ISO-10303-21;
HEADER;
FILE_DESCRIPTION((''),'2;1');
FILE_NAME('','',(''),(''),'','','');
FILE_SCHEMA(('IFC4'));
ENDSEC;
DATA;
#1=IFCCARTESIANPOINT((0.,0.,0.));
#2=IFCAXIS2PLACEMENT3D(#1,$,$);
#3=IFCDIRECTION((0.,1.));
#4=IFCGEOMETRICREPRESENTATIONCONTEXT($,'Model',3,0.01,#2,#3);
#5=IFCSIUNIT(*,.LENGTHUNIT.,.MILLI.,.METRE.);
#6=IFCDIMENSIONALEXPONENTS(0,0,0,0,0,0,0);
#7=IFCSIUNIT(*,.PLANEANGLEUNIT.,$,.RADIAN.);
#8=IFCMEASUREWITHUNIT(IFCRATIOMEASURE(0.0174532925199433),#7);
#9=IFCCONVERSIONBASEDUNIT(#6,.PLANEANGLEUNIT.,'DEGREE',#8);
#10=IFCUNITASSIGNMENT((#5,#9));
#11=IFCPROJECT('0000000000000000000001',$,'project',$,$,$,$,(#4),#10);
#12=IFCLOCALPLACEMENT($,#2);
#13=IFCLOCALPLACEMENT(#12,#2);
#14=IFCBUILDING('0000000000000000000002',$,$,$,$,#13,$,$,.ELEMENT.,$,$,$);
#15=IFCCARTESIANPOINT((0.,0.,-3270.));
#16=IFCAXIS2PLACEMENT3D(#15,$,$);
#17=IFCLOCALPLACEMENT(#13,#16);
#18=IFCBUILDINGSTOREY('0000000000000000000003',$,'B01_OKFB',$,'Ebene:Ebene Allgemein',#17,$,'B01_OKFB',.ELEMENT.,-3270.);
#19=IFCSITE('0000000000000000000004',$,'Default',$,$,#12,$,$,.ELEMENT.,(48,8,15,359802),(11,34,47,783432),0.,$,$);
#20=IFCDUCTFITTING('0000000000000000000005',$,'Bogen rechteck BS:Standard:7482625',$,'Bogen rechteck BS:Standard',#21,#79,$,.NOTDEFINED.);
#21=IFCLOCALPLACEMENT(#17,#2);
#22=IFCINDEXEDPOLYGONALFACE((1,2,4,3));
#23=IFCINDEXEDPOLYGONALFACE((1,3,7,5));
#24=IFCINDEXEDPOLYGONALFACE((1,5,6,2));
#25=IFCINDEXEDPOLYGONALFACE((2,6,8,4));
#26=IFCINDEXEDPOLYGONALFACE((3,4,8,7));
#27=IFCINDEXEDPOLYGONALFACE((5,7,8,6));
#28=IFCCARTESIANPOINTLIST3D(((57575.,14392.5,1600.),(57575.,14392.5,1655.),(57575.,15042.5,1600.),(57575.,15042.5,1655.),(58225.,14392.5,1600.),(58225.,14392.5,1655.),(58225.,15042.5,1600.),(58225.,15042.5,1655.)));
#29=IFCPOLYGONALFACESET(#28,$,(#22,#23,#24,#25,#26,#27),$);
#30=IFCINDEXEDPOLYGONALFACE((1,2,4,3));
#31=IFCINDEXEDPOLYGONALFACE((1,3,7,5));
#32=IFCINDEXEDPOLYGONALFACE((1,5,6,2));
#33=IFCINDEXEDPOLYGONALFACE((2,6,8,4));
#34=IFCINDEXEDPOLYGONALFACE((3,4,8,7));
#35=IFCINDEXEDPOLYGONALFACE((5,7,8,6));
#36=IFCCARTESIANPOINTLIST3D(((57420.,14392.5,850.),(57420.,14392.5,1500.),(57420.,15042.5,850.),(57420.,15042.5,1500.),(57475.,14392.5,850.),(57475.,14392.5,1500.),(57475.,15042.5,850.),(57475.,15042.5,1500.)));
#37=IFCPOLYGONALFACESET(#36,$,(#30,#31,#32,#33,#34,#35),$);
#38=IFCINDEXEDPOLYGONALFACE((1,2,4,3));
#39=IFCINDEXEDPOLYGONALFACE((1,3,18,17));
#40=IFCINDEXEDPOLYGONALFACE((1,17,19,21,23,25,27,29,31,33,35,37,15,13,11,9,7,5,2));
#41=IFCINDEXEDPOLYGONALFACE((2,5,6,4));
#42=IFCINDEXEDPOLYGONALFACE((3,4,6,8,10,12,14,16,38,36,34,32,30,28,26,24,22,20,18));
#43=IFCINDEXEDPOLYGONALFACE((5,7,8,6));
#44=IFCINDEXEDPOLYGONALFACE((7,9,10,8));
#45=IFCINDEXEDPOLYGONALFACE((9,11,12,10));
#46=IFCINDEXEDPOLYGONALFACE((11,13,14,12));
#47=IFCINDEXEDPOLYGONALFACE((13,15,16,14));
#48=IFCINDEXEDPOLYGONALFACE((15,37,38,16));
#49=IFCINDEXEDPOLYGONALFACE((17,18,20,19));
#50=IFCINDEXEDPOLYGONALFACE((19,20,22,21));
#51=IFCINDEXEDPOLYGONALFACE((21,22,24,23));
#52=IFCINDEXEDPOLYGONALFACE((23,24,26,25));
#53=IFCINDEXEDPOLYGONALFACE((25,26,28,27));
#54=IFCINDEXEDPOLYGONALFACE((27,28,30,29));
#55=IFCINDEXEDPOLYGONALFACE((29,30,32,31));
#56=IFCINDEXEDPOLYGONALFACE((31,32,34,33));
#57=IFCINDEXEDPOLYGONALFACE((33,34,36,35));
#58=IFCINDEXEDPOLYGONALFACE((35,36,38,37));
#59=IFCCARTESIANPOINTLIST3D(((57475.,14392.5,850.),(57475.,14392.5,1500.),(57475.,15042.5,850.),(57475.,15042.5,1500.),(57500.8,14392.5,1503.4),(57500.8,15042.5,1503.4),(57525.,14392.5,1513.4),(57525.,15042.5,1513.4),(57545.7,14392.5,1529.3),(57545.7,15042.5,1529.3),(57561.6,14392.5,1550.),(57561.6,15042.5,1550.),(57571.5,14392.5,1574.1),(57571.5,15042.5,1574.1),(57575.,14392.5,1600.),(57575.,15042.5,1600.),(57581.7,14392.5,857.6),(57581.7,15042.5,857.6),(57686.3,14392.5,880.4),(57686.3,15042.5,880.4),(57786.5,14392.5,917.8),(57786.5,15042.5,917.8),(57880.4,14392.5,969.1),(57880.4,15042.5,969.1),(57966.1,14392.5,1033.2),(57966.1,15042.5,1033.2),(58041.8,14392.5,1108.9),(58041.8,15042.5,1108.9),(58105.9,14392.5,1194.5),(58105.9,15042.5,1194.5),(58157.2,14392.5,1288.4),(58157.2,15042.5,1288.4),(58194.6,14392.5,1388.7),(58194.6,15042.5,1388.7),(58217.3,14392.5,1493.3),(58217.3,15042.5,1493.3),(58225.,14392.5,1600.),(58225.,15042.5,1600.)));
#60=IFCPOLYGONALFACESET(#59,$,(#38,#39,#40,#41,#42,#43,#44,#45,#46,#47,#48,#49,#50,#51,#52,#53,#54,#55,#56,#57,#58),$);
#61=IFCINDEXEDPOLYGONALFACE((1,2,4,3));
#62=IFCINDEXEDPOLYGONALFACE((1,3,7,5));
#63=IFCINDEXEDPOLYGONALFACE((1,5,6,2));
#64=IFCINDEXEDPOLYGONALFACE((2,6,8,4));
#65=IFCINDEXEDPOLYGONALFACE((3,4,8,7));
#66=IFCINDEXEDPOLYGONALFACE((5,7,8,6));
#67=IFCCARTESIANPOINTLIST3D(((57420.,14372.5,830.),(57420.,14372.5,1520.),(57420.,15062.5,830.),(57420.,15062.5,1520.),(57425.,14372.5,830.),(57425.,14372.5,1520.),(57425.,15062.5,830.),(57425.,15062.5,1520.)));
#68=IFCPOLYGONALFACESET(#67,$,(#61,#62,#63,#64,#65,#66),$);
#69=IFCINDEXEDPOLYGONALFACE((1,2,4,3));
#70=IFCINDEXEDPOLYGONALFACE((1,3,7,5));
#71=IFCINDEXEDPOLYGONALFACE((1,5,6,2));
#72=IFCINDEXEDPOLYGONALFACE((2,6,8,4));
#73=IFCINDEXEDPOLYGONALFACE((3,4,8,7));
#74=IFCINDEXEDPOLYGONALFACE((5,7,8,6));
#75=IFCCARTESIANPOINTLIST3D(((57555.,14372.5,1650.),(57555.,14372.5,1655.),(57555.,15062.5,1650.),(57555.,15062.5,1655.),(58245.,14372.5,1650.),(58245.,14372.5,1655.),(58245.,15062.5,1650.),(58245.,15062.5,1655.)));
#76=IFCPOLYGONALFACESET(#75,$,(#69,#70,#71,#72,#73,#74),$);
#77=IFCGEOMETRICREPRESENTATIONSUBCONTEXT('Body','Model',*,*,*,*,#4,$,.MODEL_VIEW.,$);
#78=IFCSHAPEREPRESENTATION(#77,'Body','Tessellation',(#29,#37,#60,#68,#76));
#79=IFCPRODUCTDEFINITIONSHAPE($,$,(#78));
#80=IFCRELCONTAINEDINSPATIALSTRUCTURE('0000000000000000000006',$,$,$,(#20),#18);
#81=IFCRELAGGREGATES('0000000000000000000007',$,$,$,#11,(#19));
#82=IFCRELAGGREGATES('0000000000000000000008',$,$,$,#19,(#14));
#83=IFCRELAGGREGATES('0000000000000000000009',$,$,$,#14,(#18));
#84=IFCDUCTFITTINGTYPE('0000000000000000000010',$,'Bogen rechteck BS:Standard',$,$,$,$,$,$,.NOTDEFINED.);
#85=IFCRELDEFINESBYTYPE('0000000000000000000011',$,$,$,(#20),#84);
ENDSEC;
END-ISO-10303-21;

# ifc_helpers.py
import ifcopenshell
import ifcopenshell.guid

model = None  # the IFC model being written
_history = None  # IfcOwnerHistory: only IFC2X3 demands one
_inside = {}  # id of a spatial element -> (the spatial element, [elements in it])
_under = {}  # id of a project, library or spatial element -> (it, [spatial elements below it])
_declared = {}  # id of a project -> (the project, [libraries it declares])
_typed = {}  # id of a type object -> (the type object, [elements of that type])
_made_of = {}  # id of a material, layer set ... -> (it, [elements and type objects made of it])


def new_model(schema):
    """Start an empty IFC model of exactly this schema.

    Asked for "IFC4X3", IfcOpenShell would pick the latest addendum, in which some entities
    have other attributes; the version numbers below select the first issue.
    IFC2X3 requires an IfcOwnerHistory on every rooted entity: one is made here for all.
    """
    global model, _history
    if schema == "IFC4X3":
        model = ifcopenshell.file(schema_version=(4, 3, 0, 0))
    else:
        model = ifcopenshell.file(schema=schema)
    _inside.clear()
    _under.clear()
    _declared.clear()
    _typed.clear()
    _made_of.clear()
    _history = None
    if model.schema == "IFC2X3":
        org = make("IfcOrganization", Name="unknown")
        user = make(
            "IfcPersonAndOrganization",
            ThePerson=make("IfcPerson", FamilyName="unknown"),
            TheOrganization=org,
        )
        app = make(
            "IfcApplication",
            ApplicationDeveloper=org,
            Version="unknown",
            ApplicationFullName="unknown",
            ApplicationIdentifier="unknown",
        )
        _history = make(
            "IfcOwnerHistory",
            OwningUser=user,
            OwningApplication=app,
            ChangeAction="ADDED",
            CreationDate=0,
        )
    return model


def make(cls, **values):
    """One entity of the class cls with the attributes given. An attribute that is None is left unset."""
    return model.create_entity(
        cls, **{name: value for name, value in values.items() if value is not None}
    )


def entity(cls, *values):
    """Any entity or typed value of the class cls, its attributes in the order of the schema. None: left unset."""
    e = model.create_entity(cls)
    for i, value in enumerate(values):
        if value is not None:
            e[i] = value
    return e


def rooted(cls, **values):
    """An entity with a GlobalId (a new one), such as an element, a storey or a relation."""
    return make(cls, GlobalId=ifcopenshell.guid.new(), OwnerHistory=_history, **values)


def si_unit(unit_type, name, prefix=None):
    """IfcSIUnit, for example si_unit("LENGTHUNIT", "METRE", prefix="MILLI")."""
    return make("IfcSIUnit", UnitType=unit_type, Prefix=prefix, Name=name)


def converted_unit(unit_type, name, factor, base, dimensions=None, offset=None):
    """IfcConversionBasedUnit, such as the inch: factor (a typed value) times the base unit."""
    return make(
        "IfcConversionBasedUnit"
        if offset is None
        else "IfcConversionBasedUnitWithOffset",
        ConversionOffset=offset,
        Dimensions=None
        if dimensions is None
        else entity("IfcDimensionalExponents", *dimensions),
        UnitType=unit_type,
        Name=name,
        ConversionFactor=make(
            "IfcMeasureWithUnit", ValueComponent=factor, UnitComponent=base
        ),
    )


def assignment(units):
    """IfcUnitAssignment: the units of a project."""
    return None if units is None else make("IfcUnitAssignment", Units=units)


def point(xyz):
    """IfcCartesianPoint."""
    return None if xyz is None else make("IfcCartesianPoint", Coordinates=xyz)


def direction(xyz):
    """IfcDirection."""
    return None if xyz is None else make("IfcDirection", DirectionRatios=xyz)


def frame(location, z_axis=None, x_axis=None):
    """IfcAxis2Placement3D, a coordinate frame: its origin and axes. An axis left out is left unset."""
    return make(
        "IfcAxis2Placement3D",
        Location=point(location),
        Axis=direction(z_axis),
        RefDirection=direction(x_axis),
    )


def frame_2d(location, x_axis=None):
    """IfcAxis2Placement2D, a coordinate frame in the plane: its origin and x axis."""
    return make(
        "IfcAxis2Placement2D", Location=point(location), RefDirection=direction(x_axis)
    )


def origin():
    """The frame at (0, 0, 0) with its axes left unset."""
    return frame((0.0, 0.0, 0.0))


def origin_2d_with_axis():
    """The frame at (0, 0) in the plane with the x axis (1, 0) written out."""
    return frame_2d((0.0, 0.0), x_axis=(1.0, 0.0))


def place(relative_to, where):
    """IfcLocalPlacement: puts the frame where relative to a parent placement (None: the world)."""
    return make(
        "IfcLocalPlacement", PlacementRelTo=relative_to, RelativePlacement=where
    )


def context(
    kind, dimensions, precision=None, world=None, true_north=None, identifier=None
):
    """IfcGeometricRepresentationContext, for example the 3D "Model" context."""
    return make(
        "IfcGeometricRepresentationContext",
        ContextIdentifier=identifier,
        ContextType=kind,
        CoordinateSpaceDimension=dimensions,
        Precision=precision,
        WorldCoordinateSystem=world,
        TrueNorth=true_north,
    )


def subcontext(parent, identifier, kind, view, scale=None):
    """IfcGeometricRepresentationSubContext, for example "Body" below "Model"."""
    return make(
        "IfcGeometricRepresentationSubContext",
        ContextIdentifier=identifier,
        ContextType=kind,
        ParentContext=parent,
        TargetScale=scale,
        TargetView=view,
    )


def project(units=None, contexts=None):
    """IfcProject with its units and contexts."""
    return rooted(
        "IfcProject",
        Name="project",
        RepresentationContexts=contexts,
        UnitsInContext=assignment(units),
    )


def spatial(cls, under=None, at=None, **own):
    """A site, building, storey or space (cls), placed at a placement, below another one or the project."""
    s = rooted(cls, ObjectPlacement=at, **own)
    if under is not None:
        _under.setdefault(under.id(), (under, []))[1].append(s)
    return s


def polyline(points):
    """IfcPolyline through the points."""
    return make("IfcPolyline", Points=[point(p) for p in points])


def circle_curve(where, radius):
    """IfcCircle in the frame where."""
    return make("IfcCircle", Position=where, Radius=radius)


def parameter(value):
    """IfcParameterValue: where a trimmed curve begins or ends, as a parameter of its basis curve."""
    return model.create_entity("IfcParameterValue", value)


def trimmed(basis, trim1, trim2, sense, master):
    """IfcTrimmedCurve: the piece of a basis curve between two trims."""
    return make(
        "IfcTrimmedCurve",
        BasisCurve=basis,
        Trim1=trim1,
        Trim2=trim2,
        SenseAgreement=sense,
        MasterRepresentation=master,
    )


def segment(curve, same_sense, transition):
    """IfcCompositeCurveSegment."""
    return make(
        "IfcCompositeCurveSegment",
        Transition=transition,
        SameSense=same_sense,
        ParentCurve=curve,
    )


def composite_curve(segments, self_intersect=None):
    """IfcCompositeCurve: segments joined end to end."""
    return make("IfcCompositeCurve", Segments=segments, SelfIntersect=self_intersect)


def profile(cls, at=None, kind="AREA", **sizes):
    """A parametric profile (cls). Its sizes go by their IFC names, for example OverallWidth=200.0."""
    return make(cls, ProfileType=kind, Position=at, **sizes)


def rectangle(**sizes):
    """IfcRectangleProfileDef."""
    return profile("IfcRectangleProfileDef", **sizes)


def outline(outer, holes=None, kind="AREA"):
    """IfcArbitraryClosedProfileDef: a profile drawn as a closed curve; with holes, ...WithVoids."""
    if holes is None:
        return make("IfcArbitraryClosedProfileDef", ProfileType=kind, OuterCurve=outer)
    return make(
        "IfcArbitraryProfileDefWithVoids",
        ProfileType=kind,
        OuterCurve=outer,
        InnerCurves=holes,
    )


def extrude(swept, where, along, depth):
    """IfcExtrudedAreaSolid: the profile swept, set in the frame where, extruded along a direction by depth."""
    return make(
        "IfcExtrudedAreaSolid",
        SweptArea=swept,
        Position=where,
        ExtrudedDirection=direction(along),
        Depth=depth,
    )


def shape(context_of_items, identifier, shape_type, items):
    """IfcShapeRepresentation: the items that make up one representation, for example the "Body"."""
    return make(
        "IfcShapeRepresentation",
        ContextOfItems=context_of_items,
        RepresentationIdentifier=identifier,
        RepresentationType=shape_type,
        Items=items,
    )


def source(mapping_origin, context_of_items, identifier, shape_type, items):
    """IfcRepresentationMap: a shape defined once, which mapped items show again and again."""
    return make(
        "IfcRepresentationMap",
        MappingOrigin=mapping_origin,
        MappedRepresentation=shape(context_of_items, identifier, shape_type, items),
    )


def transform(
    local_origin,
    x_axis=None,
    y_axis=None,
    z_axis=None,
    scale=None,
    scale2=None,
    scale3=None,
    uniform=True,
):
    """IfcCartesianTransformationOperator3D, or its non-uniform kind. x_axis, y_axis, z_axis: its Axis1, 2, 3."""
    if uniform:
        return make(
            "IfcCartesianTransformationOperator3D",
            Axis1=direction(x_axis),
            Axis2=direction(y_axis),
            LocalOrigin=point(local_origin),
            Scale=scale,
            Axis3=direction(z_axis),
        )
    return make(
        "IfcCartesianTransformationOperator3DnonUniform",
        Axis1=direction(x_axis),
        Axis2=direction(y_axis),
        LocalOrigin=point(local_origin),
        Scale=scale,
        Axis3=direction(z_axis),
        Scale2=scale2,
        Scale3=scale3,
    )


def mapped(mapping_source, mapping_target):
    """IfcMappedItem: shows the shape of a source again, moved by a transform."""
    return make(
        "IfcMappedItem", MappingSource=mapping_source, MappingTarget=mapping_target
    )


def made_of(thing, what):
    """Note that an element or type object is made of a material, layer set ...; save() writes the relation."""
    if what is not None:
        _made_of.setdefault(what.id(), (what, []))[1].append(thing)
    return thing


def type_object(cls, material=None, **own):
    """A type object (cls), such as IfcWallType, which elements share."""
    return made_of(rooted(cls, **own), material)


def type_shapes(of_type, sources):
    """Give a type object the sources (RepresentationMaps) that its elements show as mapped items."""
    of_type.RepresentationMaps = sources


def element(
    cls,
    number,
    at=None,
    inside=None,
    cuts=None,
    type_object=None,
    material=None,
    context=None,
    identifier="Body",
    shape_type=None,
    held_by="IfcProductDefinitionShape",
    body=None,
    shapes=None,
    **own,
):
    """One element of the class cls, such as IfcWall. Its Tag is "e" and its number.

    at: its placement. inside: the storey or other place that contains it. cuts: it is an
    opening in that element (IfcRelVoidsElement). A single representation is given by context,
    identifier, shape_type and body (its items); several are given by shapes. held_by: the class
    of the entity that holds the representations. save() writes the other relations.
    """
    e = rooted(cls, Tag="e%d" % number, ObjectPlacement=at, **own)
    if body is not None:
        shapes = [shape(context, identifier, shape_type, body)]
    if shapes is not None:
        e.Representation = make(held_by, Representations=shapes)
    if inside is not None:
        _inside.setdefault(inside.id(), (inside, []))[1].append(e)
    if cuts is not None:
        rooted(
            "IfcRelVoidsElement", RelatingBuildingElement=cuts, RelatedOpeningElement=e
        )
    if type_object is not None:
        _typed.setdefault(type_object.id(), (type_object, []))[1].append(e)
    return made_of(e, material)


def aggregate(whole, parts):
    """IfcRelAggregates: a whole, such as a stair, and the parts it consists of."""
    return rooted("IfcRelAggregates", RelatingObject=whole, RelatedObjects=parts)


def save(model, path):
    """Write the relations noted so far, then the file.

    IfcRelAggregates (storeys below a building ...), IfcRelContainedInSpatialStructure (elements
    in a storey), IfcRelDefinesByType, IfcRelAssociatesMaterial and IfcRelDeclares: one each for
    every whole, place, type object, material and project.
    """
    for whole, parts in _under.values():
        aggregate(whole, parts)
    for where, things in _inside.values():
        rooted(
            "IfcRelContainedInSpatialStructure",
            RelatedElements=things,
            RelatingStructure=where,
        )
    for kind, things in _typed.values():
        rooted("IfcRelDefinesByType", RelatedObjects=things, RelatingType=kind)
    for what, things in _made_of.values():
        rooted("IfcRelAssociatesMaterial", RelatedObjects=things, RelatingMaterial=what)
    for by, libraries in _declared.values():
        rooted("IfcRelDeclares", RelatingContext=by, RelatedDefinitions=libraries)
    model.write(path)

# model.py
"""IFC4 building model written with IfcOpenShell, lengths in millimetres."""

from ifc_helpers import new_model, entity, si_unit, converted_unit, direction, frame, frame_2d, origin, origin_2d_with_axis, place, context, subcontext, project, spatial, polyline, circle_curve, parameter, trimmed, segment, composite_curve, rectangle, outline, extrude, source, transform, mapped, type_object, type_shapes, element, save


model = new_model("IFC4")

# Units and contexts
model_context = context("Model", 3, precision=0.01, world=origin(), true_north=direction((0.0, 1.0)))
body_context = subcontext(model_context, "Body", "Model", "MODEL_VIEW")
ifc_project = project(units=[si_unit("LENGTHUNIT", "METRE", prefix="MILLI"), converted_unit("PLANEANGLEUNIT", "DEGREE", entity("IfcRatioMeasure", 0.0174532925199433), si_unit("PLANEANGLEUNIT", "RADIAN"), dimensions=[0, 0, 0, 0, 0, 0, 0])], contexts=[model_context])

# Site, building, storey
site_placement = place(None, origin())
site = spatial("IfcSite", under=ifc_project, at=site_placement, Name="Default", CompositionType="ELEMENT", RefLatitude=(48, 8, 15, 359802), RefLongitude=(11, 34, 47, 783432), RefElevation=0.0)
building_placement = place(site_placement, origin())
building = spatial("IfcBuilding", under=site, at=building_placement, CompositionType="ELEMENT")
storey_placement = place(building_placement, frame((0.0, 0.0, -3270.0)))
storey = spatial("IfcBuildingStorey", under=building, at=storey_placement, Name="B01_OKFB", ObjectType="Ebene:Ebene Allgemein", LongName="B01_OKFB", CompositionType="ELEMENT", Elevation=-3270.0)

# Duct fitting
duct_fitting_type_1 = type_object("IfcDuctFittingType", Name="Bogen rechteck BS:Standard", PredefinedType="NOTDEFINED")
shared_shape_1 = source(origin(), body_context, "Body", "SweptSolid", [
    extrude(rectangle(XDim=55.0, YDim=650.0, at=origin_2d_with_axis()), frame((0.0, 452.5, -325.0), z_axis=(0.0, 0.0, 1.0), x_axis=(0.0, 1.0, 0.0)), (0.0, 0.0, 1.0), 650.0),
    extrude(rectangle(XDim=650.0, YDim=55.0, at=frame_2d((0.0, 0.0), x_axis=(1.0, 0.0))), frame((-452.5, 0.0, -325.0), z_axis=(0.0, 0.0, 1.0), x_axis=(0.0, -1.0, 0.0)), (0.0, 0.0, 1.0), 650.0),
    extrude(outline(composite_curve([segment(polyline([(-537.5, -212.5), (112.5, -212.5)]), True, "CONTINUOUS"), segment(trimmed(circle_curve(frame_2d((212.5, -212.5), x_axis=(0.0, 1.0)), 100.0), [parameter(0.0)], [parameter(90.0)], True, "PARAMETER"), False, "CONTINUOUS"), segment(polyline([(212.5, -112.5), (212.5, 537.5)]), True, "CONTINUOUS"), segment(trimmed(circle_curve(frame_2d((212.5, -212.5), x_axis=(0.0, 1.0)), 750.0), [parameter(0.0)], [parameter(90.0)], True, "PARAMETER"), True, "CONTINUOUS")], self_intersect=False)), frame((-212.5, 212.5, -325.0), z_axis=(0.0, 0.0, 1.0), x_axis=(-1.0, 0.0, 0.0)), (0.0, 0.0, 1.0), 650.0),
    extrude(rectangle(XDim=5.0, YDim=690.0, at=frame_2d((0.0, 0.0), x_axis=(1.0, 0.0))), frame((-477.5, 0.0, -345.0)), (0.0, 0.0, 1.0), 690.0),
    extrude(rectangle(XDim=5.0, YDim=690.0, at=frame_2d((0.0, 0.0), x_axis=(1.0, 0.0))), frame((0.0, 477.5, -345.0), z_axis=(0.0, 0.0, 1.0), x_axis=(0.0, 1.0, 0.0)), (0.0, 0.0, 1.0), 690.0),
])
type_shapes(duct_fitting_type_1, [shared_shape_1])
for number, where, z_axis, x_axis, name in (
    (1, (57900.0, 14717.5, 1175.0), (0.0, -1.0, 0.0), (1.0, 0.0, 0.0), "Bogen rechteck BS:Standard:7482625"),
):
    element("IfcDuctFitting", number, at=place(storey_placement, frame(where, z_axis=z_axis, x_axis=x_axis)), inside=storey, type_object=duct_fitting_type_1, Name=name, ObjectType="Bogen rechteck BS:Standard", PredefinedType="NOTDEFINED", context=body_context, shape_type="MappedRepresentation", body=[
        mapped(shared_shape_1, transform((0.0, 0.0, 0.0), scale=1.0)),
    ])

save(model, "model.ifc")
